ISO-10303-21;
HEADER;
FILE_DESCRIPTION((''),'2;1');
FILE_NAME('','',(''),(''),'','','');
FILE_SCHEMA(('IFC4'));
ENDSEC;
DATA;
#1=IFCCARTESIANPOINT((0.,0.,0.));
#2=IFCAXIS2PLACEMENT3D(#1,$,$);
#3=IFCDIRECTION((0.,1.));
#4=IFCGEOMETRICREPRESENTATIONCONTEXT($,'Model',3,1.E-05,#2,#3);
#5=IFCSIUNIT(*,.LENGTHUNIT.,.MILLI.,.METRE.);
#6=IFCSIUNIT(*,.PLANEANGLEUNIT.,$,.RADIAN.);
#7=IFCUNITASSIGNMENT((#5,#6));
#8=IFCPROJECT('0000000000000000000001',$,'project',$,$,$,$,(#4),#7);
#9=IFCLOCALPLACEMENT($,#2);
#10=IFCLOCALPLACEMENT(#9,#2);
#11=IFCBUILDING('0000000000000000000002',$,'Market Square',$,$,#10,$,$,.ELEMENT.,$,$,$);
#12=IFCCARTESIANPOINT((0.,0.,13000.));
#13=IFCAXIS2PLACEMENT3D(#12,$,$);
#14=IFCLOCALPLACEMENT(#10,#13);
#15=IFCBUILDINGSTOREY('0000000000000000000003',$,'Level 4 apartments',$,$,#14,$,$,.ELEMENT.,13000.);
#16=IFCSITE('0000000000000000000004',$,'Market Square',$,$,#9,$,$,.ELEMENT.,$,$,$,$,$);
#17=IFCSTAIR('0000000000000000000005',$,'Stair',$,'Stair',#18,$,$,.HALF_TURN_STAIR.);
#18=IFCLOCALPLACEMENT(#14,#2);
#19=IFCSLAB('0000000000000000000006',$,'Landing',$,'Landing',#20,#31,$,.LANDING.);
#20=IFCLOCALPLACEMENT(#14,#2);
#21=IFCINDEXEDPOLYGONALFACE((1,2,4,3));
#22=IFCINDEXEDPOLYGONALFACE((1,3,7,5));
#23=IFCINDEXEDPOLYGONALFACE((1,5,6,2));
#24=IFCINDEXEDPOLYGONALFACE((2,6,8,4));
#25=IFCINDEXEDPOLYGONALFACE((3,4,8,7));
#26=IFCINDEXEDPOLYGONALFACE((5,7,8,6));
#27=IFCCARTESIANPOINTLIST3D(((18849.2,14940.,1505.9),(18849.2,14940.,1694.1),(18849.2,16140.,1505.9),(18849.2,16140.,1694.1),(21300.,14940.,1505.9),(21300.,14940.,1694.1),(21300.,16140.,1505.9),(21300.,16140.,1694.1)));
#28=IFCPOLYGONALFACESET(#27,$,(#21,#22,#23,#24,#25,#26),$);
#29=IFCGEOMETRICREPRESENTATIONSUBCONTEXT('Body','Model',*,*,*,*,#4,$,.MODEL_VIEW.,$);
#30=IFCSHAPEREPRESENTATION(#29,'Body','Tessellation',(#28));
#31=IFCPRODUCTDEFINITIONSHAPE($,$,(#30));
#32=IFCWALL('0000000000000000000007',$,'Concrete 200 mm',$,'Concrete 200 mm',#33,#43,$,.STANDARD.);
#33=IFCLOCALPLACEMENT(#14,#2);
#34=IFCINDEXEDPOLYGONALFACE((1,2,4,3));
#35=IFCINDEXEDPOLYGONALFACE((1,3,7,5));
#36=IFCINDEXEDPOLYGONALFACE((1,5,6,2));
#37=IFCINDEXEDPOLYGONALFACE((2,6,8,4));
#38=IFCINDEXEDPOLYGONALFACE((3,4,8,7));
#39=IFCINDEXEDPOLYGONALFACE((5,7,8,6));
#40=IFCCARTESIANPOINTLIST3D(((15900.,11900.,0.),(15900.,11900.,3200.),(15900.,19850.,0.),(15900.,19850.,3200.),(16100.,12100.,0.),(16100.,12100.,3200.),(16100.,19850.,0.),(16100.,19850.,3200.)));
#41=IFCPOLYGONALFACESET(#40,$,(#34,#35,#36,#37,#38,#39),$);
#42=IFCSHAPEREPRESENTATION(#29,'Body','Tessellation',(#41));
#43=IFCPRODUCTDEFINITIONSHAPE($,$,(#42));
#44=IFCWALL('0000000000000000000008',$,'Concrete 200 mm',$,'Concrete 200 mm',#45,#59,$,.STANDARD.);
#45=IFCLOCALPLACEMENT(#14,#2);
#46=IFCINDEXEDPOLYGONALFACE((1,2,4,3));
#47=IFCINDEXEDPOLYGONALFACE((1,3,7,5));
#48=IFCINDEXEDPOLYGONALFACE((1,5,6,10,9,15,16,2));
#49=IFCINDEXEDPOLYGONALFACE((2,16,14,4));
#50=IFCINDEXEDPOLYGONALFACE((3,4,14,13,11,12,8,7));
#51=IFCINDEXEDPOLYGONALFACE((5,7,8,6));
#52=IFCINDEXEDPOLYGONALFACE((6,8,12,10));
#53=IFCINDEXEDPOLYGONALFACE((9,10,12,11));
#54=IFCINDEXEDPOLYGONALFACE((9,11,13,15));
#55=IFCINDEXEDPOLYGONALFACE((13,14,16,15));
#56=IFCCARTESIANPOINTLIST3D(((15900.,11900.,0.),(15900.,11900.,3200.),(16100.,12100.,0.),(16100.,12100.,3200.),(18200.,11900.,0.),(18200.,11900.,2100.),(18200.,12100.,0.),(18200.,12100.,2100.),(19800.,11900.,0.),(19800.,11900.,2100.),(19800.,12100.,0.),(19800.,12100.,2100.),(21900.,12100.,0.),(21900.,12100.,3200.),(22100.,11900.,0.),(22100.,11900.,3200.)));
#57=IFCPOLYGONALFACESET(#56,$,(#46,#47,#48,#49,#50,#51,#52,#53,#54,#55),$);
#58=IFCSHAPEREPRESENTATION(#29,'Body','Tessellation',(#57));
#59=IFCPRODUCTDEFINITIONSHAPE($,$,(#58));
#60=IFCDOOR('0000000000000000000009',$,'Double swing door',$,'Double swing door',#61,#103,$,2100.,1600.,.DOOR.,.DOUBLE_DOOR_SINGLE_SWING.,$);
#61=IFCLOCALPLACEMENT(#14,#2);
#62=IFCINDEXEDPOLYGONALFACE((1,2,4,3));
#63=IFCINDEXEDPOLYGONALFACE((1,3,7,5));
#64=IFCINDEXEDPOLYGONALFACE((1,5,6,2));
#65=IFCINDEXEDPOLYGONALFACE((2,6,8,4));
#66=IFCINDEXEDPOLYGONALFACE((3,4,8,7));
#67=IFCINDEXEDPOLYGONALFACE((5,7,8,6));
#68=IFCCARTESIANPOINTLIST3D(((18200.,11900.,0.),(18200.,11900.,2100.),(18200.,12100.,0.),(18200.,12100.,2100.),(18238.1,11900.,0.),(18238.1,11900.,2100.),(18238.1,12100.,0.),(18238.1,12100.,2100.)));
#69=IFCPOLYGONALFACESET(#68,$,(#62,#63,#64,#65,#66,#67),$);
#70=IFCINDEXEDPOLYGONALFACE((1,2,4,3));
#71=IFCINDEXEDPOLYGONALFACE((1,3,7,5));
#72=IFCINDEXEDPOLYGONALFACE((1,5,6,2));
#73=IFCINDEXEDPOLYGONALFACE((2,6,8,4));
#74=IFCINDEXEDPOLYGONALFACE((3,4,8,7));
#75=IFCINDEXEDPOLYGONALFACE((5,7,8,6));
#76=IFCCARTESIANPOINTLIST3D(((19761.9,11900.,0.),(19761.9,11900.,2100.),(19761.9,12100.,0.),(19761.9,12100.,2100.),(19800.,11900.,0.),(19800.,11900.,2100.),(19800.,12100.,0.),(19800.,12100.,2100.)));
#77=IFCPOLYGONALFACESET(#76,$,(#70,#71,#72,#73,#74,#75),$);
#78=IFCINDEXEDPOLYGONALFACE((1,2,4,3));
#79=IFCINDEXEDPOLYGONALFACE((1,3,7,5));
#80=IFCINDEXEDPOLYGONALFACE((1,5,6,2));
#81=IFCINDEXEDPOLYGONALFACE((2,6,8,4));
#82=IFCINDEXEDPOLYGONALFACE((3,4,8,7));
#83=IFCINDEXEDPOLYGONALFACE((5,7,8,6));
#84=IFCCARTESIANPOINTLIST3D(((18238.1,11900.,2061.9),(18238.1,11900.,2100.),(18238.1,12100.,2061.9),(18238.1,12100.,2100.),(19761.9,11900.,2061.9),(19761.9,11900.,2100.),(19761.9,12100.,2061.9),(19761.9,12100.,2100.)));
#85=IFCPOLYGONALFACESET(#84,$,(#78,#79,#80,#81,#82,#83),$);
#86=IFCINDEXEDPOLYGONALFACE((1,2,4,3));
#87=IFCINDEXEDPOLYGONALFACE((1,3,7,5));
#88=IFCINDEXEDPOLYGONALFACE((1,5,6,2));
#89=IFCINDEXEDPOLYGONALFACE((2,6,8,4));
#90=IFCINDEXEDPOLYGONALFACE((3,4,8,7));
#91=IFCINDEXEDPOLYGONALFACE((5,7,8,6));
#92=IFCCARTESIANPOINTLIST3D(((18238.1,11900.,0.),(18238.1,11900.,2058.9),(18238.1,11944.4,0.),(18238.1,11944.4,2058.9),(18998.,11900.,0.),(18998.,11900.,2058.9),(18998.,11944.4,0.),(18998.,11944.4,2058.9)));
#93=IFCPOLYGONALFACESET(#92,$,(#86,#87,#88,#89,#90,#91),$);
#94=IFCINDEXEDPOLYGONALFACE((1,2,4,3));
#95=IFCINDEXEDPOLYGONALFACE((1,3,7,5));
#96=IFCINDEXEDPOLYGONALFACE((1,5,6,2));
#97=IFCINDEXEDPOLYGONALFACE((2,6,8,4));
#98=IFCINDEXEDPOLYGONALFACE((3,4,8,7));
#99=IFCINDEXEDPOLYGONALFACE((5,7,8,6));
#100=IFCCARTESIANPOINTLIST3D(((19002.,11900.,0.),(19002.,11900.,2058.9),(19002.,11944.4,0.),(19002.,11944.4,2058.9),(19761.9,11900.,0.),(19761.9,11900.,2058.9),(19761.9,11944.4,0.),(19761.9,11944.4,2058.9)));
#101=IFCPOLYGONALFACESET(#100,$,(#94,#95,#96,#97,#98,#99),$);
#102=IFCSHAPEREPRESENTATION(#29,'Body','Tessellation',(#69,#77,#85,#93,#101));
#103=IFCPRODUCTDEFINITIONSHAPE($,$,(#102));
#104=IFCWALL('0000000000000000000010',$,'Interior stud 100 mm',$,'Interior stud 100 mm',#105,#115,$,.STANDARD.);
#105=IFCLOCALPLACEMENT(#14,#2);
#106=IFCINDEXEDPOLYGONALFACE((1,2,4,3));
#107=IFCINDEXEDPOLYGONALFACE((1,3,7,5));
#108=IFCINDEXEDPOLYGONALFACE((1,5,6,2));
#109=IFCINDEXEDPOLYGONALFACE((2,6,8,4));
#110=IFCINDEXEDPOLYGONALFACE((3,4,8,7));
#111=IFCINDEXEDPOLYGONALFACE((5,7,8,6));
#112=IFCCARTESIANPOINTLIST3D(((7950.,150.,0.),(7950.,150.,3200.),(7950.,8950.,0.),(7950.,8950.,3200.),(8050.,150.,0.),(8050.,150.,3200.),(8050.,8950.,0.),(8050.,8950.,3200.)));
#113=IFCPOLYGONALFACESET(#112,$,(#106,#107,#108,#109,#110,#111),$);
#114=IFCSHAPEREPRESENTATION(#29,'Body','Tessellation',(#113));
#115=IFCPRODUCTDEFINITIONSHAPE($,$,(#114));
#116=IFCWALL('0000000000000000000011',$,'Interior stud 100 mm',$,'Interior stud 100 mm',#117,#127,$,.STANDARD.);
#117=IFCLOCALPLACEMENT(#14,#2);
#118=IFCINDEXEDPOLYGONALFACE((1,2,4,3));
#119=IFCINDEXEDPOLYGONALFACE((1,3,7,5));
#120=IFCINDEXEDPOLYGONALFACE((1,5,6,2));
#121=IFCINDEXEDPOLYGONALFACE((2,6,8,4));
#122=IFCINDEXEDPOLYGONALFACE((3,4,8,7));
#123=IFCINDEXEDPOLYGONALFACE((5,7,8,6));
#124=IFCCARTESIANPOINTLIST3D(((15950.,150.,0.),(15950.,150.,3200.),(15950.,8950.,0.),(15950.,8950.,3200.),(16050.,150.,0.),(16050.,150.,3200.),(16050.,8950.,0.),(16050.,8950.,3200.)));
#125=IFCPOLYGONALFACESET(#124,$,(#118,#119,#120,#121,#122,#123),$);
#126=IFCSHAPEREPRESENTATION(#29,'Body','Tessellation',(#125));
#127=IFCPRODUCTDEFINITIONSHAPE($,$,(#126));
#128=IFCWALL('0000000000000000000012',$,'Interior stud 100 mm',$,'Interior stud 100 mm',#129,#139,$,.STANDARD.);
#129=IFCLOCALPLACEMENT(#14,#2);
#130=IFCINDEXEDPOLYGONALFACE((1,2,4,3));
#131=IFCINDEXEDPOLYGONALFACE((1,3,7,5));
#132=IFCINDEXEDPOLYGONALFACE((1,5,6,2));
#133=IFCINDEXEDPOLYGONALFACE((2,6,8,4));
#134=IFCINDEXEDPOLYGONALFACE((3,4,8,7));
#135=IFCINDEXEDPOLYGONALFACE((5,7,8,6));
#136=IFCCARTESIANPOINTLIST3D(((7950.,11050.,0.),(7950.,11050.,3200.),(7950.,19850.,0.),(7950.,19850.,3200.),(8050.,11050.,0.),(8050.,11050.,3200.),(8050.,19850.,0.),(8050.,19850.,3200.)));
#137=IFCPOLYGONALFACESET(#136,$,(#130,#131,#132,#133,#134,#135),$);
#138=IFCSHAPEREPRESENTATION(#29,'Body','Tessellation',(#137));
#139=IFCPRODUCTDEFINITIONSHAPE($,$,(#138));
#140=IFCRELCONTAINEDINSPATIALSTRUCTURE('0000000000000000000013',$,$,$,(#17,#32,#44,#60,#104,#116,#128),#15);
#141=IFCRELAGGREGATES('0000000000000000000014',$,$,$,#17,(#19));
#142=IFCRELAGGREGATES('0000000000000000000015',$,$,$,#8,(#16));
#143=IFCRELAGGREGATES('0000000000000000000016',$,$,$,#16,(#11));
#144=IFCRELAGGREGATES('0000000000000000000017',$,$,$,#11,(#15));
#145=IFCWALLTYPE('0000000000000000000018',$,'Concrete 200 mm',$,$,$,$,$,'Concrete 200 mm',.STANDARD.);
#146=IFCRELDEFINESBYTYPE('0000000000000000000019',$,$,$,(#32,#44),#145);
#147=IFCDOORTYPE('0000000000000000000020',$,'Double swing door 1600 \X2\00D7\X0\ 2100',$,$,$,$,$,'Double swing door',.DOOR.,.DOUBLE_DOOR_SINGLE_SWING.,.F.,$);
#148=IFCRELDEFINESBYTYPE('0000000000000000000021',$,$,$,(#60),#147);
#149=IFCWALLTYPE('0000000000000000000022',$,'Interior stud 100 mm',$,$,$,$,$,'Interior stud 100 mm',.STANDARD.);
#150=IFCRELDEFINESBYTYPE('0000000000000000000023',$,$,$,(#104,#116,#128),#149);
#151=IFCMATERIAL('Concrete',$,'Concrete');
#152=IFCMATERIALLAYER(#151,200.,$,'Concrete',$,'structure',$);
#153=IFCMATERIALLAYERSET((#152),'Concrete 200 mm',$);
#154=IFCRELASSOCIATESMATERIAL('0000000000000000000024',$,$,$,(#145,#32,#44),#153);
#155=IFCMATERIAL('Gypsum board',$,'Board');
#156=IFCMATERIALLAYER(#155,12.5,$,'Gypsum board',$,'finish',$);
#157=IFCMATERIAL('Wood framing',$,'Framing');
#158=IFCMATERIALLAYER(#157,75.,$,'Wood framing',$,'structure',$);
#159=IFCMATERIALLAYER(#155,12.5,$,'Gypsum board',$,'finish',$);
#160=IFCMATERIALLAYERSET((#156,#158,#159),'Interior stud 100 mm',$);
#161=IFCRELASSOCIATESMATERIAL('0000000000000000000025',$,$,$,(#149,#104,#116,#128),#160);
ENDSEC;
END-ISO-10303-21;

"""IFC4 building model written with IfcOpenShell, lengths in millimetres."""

from ifc_helpers import new_model, si_unit, direction, frame, origin, origin_with_axes, place, context, subcontext, project, spatial, polyline, outline, extrude, material, layer, layer_set, layer_usage, type_object, element, fill, aggregate, save


model = new_model("IFC4")

# Units and contexts
model_context = context("Model", 3, precision=1e-05, world=origin(), true_north=direction((0.0, 1.0)))
body_context = subcontext(model_context, "Body", "Model", "MODEL_VIEW")
ifc_project = project(units=[si_unit("LENGTHUNIT", "METRE", prefix="MILLI"), si_unit("PLANEANGLEUNIT", "RADIAN")], contexts=[model_context])

# Site, building, storey
site_placement = place(None, origin())
site = spatial("IfcSite", under=ifc_project, at=site_placement, Name="Market Square", CompositionType="ELEMENT")
building_placement = place(site_placement, origin())
building = spatial("IfcBuilding", under=site, at=building_placement, Name="Market Square", CompositionType="ELEMENT")
storey_placement = place(building_placement, frame((0.0, 0.0, 13000.0)))
storey = spatial("IfcBuildingStorey", under=building, at=storey_placement, Name="Level 4 apartments", CompositionType="ELEMENT", Elevation=13000.0)

# Stair, slab
stair_placement = place(storey_placement, origin_with_axes())
stair = element("IfcStair", 1, at=stair_placement, inside=storey, Name="Stair", ObjectType="Stair", PredefinedType="HALF_TURN_STAIR")
slab_placement = place(storey_placement, origin_with_axes())
slab = element("IfcSlab", 2, at=slab_placement, Name="Landing", ObjectType="Landing", PredefinedType="LANDING", context=body_context, shape_type="SweptSolid", body=[
    extrude(outline(polyline([(21300.0, 14940.0), (21300.0, 16140.0), (18849.2, 16140.0), (18849.2, 14940.0), (21300.0, 14940.0)])), frame((0.0, 0.0, 1505.9)), (0.0, 0.0, 1.0), 188.2),
])

# Wall
ifc_material_1 = material(Name="Concrete", Category="Concrete")
ifc_layer_1 = layer(ifc_material_1, 200.0, Name="Concrete", Category="structure")
ifc_layer_set_1 = layer_set([ifc_layer_1], Name="Concrete 200 mm")
ifc_layer_usage_1 = layer_usage(ifc_layer_set_1, "AXIS2", "NEGATIVE", 100.0)
wall_type_1 = type_object("IfcWallType", Name="Concrete 200 mm", ElementType="Concrete 200 mm", PredefinedType="STANDARD", material=ifc_layer_set_1)
wall_1_placement = place(storey_placement, frame((16000.0, 12000.0, 0.0), z_axis=(0.0, 0.0, 1.0), x_axis=(0.0, 1.0, 0.0)))
element("IfcWall", 3, at=wall_1_placement, inside=storey, type_object=wall_type_1, material=ifc_layer_usage_1, Name="Concrete 200 mm", ObjectType="Concrete 200 mm", PredefinedType="STANDARD", context=body_context, shape_type="SweptSolid", body=[
    extrude(outline(polyline([(100.0, -100.0), (7850.0, -100.0), (7850.0, 100.0), (-100.0, 100.0), (100.0, -100.0)])), origin(), (0.0, 0.0, 1.0), 3200.0),
])

# Wall, opening, door
ifc_layer_usage_2 = layer_usage(ifc_layer_set_1, "AXIS2", "NEGATIVE", 100.0)
wall_2_placement = place(storey_placement, frame((16000.0, 12000.0, 0.0), z_axis=(0.0, 0.0, 1.0), x_axis=(1.0, 0.0, 0.0)))
wall_2 = element("IfcWall", 4, at=wall_2_placement, inside=storey, type_object=wall_type_1, material=ifc_layer_usage_2, Name="Concrete 200 mm", ObjectType="Concrete 200 mm", PredefinedType="STANDARD", context=body_context, shape_type="SweptSolid", body=[
    extrude(outline(polyline([(-100.0, -100.0), (6100.0, -100.0), (5900.0, 100.0), (100.0, 100.0), (-100.0, -100.0)])), origin(), (0.0, 0.0, 1.0), 3200.0),
])
opening_placement = place(wall_2_placement, frame((2200.0, 0.0, 0.0), z_axis=(0.0, 0.0, 1.0), x_axis=(1.0, 0.0, 0.0)))
opening = element("IfcOpeningElement", 5, at=opening_placement, cuts=wall_2, PredefinedType="OPENING", context=body_context, shape_type="SweptSolid", body=[
    extrude(outline(polyline([(0.0, -110.0), (1600.0, -110.0), (1600.0, 110.0), (0.0, 110.0), (0.0, -110.0)])), origin(), (0.0, 0.0, 1.0), 2100.0),
])
door_type = type_object("IfcDoorType", Name="Double swing door 1600 × 2100", ElementType="Double swing door", OperationType="DOUBLE_DOOR_SINGLE_SWING", ParameterTakesPrecedence=False, PredefinedType="DOOR")
door_placement = place(opening_placement, origin_with_axes())
door = element("IfcDoor", 6, at=door_placement, inside=storey, type_object=door_type, Name="Double swing door", ObjectType="Double swing door", OperationType="DOUBLE_DOOR_SINGLE_SWING", OverallHeight=2100.0, OverallWidth=1600.0, PredefinedType="DOOR", context=body_context, shape_type="SweptSolid", body=[
    extrude(outline(polyline([(0.0, -100.0), (38.1, -100.0), (38.1, 100.0), (0.0, 100.0), (0.0, -100.0)])), origin(), (0.0, 0.0, 1.0), 2100.0),
    extrude(outline(polyline([(1561.9, -100.0), (1600.0, -100.0), (1600.0, 100.0), (1561.9, 100.0), (1561.9, -100.0)])), origin(), (0.0, 0.0, 1.0), 2100.0),
    extrude(outline(polyline([(38.1, -100.0), (1561.9, -100.0), (1561.9, 100.0), (38.1, 100.0), (38.1, -100.0)])), frame((0.0, 0.0, 2061.9)), (0.0, 0.0, 1.0), 38.1),
    extrude(outline(polyline([(38.1, -100.0), (798.0, -100.0), (798.0, -55.5), (38.1, -55.5), (38.1, -100.0)])), origin(), (0.0, 0.0, 1.0), 2058.9),
    extrude(outline(polyline([(802.0, -100.0), (1561.9, -100.0), (1561.9, -55.5), (802.0, -55.5), (802.0, -100.0)])), origin(), (0.0, 0.0, 1.0), 2058.9),
])
fill(opening, door)

# Walls
ifc_material_2 = material(Name="Gypsum board", Category="Board")
ifc_layer_2 = layer(ifc_material_2, 12.5, Name="Gypsum board", Category="finish")
ifc_material_3 = material(Name="Wood framing", Category="Framing")
ifc_layer_3 = layer(ifc_material_3, 75.0, Name="Wood framing", Category="structure")
ifc_layer_4 = layer(ifc_material_2, 12.5, Name="Gypsum board", Category="finish")
ifc_layer_set_2 = layer_set([ifc_layer_2, ifc_layer_3, ifc_layer_4], Name="Interior stud 100 mm")
ifc_layer_usage_3 = layer_usage(ifc_layer_set_2, "AXIS2", "NEGATIVE", 50.0)
wall_type_2 = type_object("IfcWallType", Name="Interior stud 100 mm", ElementType="Interior stud 100 mm", PredefinedType="STANDARD", material=ifc_layer_set_2)
wall_3_placement = place(storey_placement, frame((8000.0, 0.0, 0.0), z_axis=(0.0, 0.0, 1.0), x_axis=(0.0, 1.0, 0.0)))
element("IfcWall", 7, at=wall_3_placement, inside=storey, type_object=wall_type_2, material=ifc_layer_usage_3, Name="Interior stud 100 mm", ObjectType="Interior stud 100 mm", PredefinedType="STANDARD", context=body_context, shape_type="SweptSolid", body=[
    extrude(outline(polyline([(150.0, -50.0), (8950.0, -50.0), (8950.0, 50.0), (150.0, 50.0), (150.0, -50.0)])), origin(), (0.0, 0.0, 1.0), 3200.0),
])
ifc_layer_usage_4 = layer_usage(ifc_layer_set_2, "AXIS2", "NEGATIVE", 50.0)
wall_4_placement = place(storey_placement, frame((16000.0, 0.0, 0.0), z_axis=(0.0, 0.0, 1.0), x_axis=(0.0, 1.0, 0.0)))
element("IfcWall", 8, at=wall_4_placement, inside=storey, type_object=wall_type_2, material=ifc_layer_usage_4, Name="Interior stud 100 mm", ObjectType="Interior stud 100 mm", PredefinedType="STANDARD", context=body_context, shape_type="SweptSolid", body=[
    extrude(outline(polyline([(150.0, -50.0), (8950.0, -50.0), (8950.0, 50.0), (150.0, 50.0), (150.0, -50.0)])), origin(), (0.0, 0.0, 1.0), 3200.0),
])
ifc_layer_usage_5 = layer_usage(ifc_layer_set_2, "AXIS2", "NEGATIVE", 50.0)
wall_5_placement = place(storey_placement, frame((8000.0, 11000.0, 0.0), z_axis=(0.0, 0.0, 1.0), x_axis=(0.0, 1.0, 0.0)))
element("IfcWall", 9, at=wall_5_placement, inside=storey, type_object=wall_type_2, material=ifc_layer_usage_5, Name="Interior stud 100 mm", ObjectType="Interior stud 100 mm", PredefinedType="STANDARD", context=body_context, shape_type="SweptSolid", body=[
    extrude(outline(polyline([(50.0, -50.0), (8850.0, -50.0), (8850.0, 50.0), (50.0, 50.0), (50.0, -50.0)])), origin(), (0.0, 0.0, 1.0), 3200.0),
])

aggregate(stair, [slab])

save(model, "model.ifc")
